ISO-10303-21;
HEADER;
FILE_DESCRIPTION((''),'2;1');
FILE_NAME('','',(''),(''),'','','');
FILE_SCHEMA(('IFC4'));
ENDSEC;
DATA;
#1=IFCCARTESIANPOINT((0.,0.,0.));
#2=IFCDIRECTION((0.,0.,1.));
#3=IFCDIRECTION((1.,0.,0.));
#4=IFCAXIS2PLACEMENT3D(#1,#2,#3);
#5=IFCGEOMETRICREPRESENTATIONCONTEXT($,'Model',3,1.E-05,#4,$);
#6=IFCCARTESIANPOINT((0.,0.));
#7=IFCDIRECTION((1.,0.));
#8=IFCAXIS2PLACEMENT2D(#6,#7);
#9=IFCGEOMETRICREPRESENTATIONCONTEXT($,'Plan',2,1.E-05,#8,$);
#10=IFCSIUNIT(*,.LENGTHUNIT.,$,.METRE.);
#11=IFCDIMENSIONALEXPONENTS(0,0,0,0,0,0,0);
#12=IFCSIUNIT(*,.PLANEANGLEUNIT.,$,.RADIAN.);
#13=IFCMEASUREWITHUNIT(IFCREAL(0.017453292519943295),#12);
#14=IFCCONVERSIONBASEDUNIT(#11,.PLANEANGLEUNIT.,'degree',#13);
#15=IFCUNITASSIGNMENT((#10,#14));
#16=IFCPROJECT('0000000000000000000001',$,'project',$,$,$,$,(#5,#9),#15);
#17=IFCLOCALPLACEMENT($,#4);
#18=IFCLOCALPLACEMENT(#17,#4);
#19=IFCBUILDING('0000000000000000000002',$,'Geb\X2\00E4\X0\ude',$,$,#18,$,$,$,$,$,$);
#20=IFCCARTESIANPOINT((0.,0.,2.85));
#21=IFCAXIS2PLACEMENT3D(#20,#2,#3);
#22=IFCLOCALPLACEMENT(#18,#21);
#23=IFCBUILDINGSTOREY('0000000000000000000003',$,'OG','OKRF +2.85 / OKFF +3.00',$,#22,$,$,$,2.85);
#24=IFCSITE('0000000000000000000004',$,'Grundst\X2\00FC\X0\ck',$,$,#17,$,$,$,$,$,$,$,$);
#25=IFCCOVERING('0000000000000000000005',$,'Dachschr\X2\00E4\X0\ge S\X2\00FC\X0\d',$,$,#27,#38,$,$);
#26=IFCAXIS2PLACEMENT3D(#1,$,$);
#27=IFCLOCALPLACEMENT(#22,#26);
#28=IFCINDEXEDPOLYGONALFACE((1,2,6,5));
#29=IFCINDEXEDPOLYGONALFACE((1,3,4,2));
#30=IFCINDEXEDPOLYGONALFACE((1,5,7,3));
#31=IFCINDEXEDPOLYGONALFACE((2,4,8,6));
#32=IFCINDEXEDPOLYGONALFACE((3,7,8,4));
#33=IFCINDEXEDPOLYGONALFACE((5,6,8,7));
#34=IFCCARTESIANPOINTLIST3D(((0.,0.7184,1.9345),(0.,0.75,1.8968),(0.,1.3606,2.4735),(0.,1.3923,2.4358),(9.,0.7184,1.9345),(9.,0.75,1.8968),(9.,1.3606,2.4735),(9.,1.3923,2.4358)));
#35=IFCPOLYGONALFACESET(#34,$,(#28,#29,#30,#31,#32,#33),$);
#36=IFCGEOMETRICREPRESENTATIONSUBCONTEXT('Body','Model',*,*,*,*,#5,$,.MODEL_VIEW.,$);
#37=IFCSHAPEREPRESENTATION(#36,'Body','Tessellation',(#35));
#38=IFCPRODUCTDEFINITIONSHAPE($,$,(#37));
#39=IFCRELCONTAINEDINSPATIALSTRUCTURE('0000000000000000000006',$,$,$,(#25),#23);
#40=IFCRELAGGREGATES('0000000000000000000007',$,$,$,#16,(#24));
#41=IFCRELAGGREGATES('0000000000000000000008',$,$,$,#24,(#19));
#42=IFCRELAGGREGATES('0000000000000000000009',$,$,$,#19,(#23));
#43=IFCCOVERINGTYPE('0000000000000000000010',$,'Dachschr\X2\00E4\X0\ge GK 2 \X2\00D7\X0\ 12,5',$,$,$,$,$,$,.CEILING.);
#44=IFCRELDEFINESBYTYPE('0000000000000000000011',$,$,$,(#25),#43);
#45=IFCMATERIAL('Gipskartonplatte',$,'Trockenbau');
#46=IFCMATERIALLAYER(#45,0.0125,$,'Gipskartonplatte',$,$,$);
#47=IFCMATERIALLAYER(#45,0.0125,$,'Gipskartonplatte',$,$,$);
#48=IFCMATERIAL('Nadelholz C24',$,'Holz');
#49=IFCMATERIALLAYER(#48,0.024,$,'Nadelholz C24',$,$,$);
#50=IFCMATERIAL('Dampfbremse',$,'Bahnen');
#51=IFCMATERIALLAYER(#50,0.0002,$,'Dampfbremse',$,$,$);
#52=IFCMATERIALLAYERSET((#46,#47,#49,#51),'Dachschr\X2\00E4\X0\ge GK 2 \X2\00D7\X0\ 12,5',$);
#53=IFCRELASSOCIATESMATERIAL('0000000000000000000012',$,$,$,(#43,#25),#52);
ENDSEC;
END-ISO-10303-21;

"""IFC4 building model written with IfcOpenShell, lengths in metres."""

from ifc_helpers import new_model, entity, si_unit, converted_unit, frame, origin_with_axes, origin_2d_with_axis, place, context, subcontext, project, spatial, indexed_curve, outline, extrude, material, layer, layer_set, layer_usage, type_object, element, save


model = new_model("IFC4")

# Units and contexts
model_context = context("Model", 3, precision=1e-05, world=origin_with_axes())
plan_context = context("Plan", 2, precision=1e-05, world=origin_2d_with_axis())
body_context = subcontext(model_context, "Body", "Model", "MODEL_VIEW")
ifc_project = project(units=[si_unit("LENGTHUNIT", "METRE"), converted_unit("PLANEANGLEUNIT", "degree", entity("IfcReal", 0.017453292519943295), si_unit("PLANEANGLEUNIT", "RADIAN"), dimensions=[0, 0, 0, 0, 0, 0, 0])], contexts=[model_context, plan_context])

# Site, building, storey
site_placement = place(None, origin_with_axes())
site = spatial("IfcSite", under=ifc_project, at=site_placement, Name="Grundstück")
building_placement = place(site_placement, origin_with_axes())
building = spatial("IfcBuilding", under=site, at=building_placement, Name="Gebäude")
storey_placement = place(building_placement, frame((0.0, 0.0, 2.85), z_axis=(0.0, 0.0, 1.0), x_axis=(1.0, 0.0, 0.0)))
storey = spatial("IfcBuildingStorey", under=building, at=storey_placement, Name="OG", Description="OKRF +2.85 / OKFF +3.00", Elevation=2.85)

# Shared definitions
ifc_material_1 = material(Name="Nadelholz C24", Category="Holz")

# Shared definitions
ifc_material_2 = material(Name="Gipskartonplatte", Category="Trockenbau")
ifc_material_3 = material(Name="Dampfbremse", Category="Bahnen")

# Covering
ifc_layer_1 = layer(ifc_material_2, 0.0125, Name="Gipskartonplatte")
ifc_layer_2 = layer(ifc_material_2, 0.0125, Name="Gipskartonplatte")
ifc_layer_3 = layer(ifc_material_1, 0.024, Name="Nadelholz C24")
ifc_layer_4 = layer(ifc_material_3, 0.0002, Name="Dampfbremse")
ifc_layer_set_1 = layer_set([ifc_layer_1, ifc_layer_2, ifc_layer_3, ifc_layer_4], Name="Dachschräge GK 2 × 12,5")
ifc_layer_usage_1 = layer_usage(ifc_layer_set_1, "AXIS3", "POSITIVE", 0.0)
covering_type_1 = type_object("IfcCoveringType", Name="Dachschräge GK 2 × 12,5", PredefinedType="CEILING", material=ifc_layer_set_1)
covering_1_placement = place(storey_placement, frame((0.0, 0.75, 1.8968), z_axis=(0.0, -0.642788, 0.766044), x_axis=(1.0, 0.0, 0.0)))
element("IfcCovering", 1, at=covering_1_placement, inside=storey, type_object=covering_type_1, material=ifc_layer_usage_1, Name="Dachschräge Süd", context=body_context, shape_type="SweptSolid", body=[
    extrude(outline(indexed_curve([(0.0, 0.0), (9.0, 0.0), (9.0, 0.8384), (0.0, 0.8384)])), None, (0.0, 0.0, 1.0), 0.0492),
])

save(model, "model.ifc")
